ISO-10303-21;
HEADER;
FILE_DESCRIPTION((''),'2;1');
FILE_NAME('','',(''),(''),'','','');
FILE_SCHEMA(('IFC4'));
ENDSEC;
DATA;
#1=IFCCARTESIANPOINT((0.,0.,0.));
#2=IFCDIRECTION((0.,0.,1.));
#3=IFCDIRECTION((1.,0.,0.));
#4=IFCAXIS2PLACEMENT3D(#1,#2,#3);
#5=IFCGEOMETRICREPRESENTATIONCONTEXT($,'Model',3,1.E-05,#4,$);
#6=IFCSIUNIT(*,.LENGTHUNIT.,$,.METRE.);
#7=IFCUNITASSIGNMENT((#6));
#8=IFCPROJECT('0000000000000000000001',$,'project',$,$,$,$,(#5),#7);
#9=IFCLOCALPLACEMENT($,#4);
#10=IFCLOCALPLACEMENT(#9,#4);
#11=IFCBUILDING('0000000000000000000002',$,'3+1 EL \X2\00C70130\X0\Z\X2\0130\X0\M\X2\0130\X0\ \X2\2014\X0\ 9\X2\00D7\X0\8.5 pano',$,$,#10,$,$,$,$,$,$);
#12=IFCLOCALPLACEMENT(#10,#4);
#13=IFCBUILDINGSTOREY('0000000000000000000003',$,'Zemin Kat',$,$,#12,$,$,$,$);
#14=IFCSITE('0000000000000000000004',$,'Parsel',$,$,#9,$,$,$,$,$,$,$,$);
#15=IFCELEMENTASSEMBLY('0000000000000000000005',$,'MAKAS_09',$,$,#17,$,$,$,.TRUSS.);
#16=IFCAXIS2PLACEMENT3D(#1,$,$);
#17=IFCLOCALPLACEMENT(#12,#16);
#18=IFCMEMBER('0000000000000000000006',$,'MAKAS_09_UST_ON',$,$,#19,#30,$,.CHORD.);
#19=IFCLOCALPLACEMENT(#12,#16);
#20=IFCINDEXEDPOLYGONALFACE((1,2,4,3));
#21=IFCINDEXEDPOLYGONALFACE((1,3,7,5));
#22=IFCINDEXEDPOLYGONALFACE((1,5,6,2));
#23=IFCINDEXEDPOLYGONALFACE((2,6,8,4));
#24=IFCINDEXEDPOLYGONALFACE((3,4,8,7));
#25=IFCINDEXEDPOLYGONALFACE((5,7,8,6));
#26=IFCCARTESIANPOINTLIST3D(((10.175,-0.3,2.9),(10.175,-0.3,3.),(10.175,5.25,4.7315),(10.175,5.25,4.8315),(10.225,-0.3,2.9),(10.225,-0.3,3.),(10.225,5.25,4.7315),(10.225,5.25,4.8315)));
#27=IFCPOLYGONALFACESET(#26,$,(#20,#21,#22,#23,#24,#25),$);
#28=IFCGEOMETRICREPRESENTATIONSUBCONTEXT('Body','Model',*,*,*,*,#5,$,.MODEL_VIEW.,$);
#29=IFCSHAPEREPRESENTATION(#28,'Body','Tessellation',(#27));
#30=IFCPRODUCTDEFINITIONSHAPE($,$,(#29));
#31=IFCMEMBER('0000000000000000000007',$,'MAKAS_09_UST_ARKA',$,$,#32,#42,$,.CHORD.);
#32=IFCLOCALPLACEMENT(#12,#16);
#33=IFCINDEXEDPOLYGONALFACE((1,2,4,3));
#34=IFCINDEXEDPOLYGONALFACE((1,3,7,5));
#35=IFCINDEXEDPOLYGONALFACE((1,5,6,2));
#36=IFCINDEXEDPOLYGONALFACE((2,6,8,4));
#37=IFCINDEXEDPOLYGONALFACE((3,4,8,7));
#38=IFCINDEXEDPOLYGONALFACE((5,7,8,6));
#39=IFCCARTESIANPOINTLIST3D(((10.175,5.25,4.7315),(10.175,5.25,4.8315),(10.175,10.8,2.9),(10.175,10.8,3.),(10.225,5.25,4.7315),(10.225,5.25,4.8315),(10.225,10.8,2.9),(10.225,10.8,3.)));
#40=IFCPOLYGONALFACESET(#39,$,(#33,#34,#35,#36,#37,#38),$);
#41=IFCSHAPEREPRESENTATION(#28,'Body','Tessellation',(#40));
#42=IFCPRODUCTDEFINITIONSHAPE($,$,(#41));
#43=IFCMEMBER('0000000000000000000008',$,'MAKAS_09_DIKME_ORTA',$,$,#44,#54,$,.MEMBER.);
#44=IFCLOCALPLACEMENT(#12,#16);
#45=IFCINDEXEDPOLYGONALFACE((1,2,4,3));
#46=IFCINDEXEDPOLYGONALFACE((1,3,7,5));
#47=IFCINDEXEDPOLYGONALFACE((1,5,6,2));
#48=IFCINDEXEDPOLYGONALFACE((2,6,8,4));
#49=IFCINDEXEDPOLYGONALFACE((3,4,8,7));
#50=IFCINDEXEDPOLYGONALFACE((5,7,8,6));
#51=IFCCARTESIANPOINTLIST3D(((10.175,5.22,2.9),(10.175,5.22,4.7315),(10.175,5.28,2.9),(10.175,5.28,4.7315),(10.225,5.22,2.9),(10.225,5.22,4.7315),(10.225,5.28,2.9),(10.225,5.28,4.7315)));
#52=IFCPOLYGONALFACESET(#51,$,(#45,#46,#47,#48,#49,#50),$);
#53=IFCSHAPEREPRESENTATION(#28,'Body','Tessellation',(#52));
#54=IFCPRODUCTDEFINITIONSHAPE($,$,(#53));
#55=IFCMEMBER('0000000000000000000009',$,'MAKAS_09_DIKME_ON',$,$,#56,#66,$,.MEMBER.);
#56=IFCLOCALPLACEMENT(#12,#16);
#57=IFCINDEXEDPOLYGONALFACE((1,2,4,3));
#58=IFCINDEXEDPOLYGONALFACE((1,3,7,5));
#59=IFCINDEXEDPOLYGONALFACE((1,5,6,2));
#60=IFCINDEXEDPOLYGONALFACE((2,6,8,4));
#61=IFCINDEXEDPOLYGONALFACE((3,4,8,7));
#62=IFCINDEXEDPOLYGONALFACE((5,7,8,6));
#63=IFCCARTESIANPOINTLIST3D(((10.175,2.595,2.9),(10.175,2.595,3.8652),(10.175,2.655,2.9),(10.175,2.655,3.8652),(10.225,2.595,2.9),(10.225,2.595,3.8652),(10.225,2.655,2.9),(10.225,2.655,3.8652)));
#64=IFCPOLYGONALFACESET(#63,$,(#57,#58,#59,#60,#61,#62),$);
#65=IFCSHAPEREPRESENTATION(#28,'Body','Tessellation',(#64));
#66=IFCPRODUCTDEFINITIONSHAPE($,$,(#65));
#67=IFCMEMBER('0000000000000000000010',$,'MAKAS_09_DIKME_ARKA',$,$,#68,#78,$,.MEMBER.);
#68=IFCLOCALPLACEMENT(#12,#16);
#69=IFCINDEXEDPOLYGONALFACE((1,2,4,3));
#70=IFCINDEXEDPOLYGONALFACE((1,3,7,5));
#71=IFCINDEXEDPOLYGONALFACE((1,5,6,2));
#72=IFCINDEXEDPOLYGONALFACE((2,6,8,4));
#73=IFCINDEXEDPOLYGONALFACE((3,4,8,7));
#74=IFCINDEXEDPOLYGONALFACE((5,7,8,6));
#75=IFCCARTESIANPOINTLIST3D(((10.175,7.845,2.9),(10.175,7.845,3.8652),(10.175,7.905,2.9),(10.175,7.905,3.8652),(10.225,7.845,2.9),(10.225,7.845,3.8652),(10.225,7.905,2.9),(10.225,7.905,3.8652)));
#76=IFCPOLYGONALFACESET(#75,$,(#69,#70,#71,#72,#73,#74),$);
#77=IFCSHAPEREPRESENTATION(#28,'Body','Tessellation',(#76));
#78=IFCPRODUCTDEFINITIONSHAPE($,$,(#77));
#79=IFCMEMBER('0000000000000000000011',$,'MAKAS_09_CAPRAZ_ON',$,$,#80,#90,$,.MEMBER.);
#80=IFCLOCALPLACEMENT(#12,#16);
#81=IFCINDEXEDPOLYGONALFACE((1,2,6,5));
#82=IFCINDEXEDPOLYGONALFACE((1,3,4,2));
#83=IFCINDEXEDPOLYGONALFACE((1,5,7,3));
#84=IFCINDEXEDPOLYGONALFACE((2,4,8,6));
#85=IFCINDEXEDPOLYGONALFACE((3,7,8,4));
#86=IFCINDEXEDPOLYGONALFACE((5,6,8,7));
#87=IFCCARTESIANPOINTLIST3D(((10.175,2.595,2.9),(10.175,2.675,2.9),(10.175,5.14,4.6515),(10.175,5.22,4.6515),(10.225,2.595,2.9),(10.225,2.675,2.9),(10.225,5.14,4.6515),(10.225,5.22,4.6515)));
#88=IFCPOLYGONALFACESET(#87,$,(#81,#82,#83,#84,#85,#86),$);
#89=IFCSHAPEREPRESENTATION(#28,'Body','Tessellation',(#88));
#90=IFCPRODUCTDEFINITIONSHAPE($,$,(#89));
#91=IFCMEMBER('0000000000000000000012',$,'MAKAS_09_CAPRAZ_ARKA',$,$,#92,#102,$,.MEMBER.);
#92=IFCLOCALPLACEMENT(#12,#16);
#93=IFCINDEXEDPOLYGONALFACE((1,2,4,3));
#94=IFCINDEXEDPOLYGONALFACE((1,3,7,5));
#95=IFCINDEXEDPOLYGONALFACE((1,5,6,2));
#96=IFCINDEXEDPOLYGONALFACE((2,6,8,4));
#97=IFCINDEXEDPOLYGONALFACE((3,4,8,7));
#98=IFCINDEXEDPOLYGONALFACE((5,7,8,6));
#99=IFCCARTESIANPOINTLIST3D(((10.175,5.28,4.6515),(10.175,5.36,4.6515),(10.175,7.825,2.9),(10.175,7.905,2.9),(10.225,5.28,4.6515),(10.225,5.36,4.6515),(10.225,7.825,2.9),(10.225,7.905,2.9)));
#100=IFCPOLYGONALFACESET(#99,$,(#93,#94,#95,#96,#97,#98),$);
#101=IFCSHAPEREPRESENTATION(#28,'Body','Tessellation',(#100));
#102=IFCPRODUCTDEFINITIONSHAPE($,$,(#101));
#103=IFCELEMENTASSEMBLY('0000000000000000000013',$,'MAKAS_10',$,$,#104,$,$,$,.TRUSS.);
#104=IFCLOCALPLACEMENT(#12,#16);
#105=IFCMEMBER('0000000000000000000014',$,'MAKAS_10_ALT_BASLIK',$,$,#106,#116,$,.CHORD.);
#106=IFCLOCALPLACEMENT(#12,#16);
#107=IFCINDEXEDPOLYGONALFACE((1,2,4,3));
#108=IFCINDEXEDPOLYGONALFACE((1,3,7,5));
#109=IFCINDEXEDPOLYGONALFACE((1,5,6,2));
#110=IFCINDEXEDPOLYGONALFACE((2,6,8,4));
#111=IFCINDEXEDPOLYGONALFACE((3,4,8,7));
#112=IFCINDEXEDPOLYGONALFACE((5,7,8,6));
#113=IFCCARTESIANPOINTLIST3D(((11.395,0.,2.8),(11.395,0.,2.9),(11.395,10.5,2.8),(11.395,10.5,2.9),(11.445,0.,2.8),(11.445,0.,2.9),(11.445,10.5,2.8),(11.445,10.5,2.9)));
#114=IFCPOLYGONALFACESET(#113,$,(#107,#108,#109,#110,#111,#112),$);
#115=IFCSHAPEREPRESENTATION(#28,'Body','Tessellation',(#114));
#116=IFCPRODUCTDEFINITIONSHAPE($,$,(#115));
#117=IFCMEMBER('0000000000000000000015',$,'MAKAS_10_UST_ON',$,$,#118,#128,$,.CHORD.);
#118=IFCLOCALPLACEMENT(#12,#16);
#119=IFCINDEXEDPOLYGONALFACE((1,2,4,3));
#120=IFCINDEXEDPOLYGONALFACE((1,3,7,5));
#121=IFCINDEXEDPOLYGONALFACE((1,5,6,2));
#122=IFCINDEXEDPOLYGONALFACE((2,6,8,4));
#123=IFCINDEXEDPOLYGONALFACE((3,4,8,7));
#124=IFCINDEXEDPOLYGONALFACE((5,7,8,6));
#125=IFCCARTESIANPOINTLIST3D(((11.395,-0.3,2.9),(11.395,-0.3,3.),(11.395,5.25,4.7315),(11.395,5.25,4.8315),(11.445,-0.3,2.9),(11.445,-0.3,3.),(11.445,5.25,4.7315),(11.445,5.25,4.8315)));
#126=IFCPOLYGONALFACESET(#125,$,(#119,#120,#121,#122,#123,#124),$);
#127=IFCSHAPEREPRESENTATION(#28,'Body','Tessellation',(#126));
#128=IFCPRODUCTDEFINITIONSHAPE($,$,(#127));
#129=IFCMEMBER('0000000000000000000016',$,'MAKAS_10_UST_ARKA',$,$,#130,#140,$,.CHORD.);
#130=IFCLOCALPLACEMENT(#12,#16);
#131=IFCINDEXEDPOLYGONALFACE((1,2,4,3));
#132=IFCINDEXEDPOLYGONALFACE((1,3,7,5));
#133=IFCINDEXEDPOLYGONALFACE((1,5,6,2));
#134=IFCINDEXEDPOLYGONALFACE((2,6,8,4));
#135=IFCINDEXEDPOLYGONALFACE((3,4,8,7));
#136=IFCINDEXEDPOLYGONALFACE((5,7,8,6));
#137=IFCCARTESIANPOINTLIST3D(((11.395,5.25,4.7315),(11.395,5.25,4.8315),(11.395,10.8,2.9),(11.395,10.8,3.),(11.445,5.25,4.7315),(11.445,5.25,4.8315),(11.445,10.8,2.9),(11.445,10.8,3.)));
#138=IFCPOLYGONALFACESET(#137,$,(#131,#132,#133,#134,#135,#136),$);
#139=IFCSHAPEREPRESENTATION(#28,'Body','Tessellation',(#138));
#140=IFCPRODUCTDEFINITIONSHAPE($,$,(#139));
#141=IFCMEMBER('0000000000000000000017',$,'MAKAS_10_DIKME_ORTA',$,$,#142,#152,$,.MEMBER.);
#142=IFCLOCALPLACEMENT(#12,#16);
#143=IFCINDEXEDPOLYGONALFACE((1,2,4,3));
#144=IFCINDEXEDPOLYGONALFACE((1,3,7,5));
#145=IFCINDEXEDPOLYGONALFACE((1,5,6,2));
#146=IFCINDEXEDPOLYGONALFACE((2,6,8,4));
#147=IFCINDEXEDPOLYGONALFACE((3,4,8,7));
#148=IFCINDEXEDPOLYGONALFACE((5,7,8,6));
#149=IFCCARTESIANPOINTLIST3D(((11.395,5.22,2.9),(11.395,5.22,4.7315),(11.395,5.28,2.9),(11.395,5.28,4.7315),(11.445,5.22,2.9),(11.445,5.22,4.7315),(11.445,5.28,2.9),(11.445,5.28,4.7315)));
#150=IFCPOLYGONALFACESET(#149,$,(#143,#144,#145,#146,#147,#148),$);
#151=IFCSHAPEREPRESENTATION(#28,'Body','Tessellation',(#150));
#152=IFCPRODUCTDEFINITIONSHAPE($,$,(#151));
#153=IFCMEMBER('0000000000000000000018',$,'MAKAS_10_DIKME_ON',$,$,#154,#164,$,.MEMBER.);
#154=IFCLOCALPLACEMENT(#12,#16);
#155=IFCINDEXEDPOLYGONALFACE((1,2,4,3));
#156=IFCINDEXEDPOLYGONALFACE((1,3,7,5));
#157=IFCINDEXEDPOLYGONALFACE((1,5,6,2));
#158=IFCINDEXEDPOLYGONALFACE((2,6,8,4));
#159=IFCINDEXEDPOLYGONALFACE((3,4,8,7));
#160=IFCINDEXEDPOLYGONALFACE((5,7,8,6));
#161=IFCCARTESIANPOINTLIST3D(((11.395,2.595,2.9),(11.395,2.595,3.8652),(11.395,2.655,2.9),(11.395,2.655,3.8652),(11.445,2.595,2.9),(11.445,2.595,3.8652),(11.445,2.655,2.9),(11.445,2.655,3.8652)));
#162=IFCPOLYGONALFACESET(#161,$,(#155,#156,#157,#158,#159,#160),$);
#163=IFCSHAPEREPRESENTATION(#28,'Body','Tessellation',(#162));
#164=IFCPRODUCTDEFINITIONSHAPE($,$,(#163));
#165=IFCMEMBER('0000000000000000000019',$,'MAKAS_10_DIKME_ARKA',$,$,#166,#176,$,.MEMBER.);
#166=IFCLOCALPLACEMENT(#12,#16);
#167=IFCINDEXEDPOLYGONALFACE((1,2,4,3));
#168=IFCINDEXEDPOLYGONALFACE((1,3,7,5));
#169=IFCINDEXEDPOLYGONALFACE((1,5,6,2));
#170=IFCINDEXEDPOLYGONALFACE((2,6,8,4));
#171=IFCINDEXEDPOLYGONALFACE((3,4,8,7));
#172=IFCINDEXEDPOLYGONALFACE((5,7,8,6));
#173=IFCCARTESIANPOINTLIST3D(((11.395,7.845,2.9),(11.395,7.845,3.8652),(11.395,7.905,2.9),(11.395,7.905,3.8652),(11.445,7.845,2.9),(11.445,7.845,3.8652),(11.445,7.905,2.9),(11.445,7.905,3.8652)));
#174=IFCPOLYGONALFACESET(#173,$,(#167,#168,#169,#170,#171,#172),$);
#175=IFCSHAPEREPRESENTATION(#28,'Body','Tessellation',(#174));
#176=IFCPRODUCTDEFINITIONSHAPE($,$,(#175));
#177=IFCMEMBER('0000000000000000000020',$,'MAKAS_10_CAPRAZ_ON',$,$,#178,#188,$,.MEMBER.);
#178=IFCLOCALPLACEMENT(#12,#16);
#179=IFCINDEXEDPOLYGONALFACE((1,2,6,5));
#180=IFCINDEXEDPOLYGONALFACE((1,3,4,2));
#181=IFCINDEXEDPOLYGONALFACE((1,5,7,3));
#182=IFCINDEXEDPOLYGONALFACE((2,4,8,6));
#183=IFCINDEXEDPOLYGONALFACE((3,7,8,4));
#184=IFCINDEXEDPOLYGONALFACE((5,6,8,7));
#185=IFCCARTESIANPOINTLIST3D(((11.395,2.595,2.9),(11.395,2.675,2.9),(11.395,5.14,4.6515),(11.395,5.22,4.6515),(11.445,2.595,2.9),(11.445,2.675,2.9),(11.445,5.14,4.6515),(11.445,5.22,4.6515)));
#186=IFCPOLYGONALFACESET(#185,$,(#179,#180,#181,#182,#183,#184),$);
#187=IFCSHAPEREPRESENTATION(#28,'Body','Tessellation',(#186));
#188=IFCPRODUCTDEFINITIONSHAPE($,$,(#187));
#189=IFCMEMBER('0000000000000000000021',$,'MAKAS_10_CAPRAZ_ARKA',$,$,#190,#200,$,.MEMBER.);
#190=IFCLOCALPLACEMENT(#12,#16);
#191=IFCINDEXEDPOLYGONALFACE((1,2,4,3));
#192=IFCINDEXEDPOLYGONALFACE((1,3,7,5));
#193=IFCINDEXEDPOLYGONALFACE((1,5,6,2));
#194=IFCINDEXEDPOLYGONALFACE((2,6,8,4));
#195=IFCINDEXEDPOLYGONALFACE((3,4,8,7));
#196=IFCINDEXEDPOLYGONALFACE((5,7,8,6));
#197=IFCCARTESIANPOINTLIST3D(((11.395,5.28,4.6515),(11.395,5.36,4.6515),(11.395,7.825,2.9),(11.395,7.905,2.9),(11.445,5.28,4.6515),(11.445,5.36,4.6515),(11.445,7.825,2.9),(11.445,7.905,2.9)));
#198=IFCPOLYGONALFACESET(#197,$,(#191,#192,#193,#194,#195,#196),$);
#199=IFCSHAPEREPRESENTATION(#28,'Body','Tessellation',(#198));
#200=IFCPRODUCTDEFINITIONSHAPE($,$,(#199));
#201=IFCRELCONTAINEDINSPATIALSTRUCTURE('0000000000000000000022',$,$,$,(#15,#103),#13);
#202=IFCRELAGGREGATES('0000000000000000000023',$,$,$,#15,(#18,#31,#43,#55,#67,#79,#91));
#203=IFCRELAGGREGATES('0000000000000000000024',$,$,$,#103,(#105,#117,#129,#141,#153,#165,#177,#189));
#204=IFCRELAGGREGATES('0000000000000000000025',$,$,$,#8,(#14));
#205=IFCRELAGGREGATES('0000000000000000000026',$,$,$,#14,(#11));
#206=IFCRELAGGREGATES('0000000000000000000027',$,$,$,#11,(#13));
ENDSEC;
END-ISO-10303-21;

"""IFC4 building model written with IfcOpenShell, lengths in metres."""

from ifc_helpers import new_model, si_unit, frame, origin_with_axes, place, context, subcontext, project, spatial, line, indexed_curve, outline, extrude, element, aggregate, save


model = new_model("IFC4")

# Units and contexts
model_context = context("Model", 3, precision=1e-05, world=origin_with_axes())
body_context = subcontext(model_context, "Body", "Model", "MODEL_VIEW")
ifc_project = project(units=[si_unit("LENGTHUNIT", "METRE")], contexts=[model_context])

# Site, building, storey
site_placement = place(None, origin_with_axes())
site = spatial("IfcSite", under=ifc_project, at=site_placement, Name="Parsel")
building_placement = place(site_placement, origin_with_axes())
building = spatial("IfcBuilding", under=site, at=building_placement, Name="3+1 EL ÇİZİMİ — 9×8.5 pano")
storey_placement = place(building_placement, origin_with_axes())
storey = spatial("IfcBuildingStorey", under=building, at=storey_placement, Name="Zemin Kat")

# Element assemblies, members
assembly_1_placement = place(storey_placement, origin_with_axes())
assembly_1 = element("IfcElementAssembly", 1, at=assembly_1_placement, inside=storey, Name="MAKAS_09", PredefinedType="TRUSS")
member_1_placement = place(assembly_1_placement, origin_with_axes())
member_1 = element("IfcMember", 2, at=member_1_placement, Name="MAKAS_09_UST_ON", PredefinedType="CHORD", context=body_context, shape_type="SweptSolid", body=[
    extrude(outline(indexed_curve([(-0.3, 2.9), (5.25, 4.7315), (5.25, 4.8315), (-0.3, 3.0)], segments=[line(1, 2, 3, 4, 1)])), frame((10.175, 0.0, 0.0), z_axis=(1.0, 0.0, 0.0), x_axis=(0.0, 1.0, 0.0)), (0.0, 0.0, 1.0), 0.05),
])
member_2_placement = place(assembly_1_placement, origin_with_axes())
member_2 = element("IfcMember", 3, at=member_2_placement, Name="MAKAS_09_UST_ARKA", PredefinedType="CHORD", context=body_context, shape_type="SweptSolid", body=[
    extrude(outline(indexed_curve([(5.25, 4.7315), (10.8, 2.9), (10.8, 3.0), (5.25, 4.8315)], segments=[line(1, 2, 3, 4, 1)])), frame((10.175, 0.0, 0.0), z_axis=(1.0, 0.0, 0.0), x_axis=(0.0, 1.0, 0.0)), (0.0, 0.0, 1.0), 0.05),
])
member_3_placement = place(assembly_1_placement, origin_with_axes())
member_3 = element("IfcMember", 4, at=member_3_placement, Name="MAKAS_09_DIKME_ORTA", PredefinedType="MEMBER", context=body_context, shape_type="SweptSolid", body=[
    extrude(outline(indexed_curve([(5.22, 2.9), (5.28, 2.9), (5.28, 4.7315), (5.22, 4.7315)], segments=[line(1, 2, 3, 4, 1)])), frame((10.175, 0.0, 0.0), z_axis=(1.0, 0.0, 0.0), x_axis=(0.0, 1.0, 0.0)), (0.0, 0.0, 1.0), 0.05),
])
member_4_placement = place(assembly_1_placement, origin_with_axes())
member_4 = element("IfcMember", 5, at=member_4_placement, Name="MAKAS_09_DIKME_ON", PredefinedType="MEMBER", context=body_context, shape_type="SweptSolid", body=[
    extrude(outline(indexed_curve([(2.595, 2.9), (2.655, 2.9), (2.655, 3.8653), (2.595, 3.8653)], segments=[line(1, 2, 3, 4, 1)])), frame((10.175, 0.0, 0.0), z_axis=(1.0, 0.0, 0.0), x_axis=(0.0, 1.0, 0.0)), (0.0, 0.0, 1.0), 0.05),
])
member_5_placement = place(assembly_1_placement, origin_with_axes())
member_5 = element("IfcMember", 6, at=member_5_placement, Name="MAKAS_09_DIKME_ARKA", PredefinedType="MEMBER", context=body_context, shape_type="SweptSolid", body=[
    extrude(outline(indexed_curve([(7.845, 2.9), (7.905, 2.9), (7.905, 3.8653), (7.845, 3.8653)], segments=[line(1, 2, 3, 4, 1)])), frame((10.175, 0.0, 0.0), z_axis=(1.0, 0.0, 0.0), x_axis=(0.0, 1.0, 0.0)), (0.0, 0.0, 1.0), 0.05),
])
member_6_placement = place(assembly_1_placement, origin_with_axes())
member_6 = element("IfcMember", 7, at=member_6_placement, Name="MAKAS_09_CAPRAZ_ON", PredefinedType="MEMBER", context=body_context, shape_type="SweptSolid", body=[
    extrude(outline(indexed_curve([(2.595, 2.9), (2.675, 2.9), (5.22, 4.6515), (5.14, 4.6515)], segments=[line(1, 2, 3, 4, 1)])), frame((10.175, 0.0, 0.0), z_axis=(1.0, 0.0, 0.0), x_axis=(0.0, 1.0, 0.0)), (0.0, 0.0, 1.0), 0.05),
])
member_7_placement = place(assembly_1_placement, origin_with_axes())
member_7 = element("IfcMember", 8, at=member_7_placement, Name="MAKAS_09_CAPRAZ_ARKA", PredefinedType="MEMBER", context=body_context, shape_type="SweptSolid", body=[
    extrude(outline(indexed_curve([(7.825, 2.9), (7.905, 2.9), (5.36, 4.6515), (5.28, 4.6515)], segments=[line(1, 2, 3, 4, 1)])), frame((10.175, 0.0, 0.0), z_axis=(1.0, 0.0, 0.0), x_axis=(0.0, 1.0, 0.0)), (0.0, 0.0, 1.0), 0.05),
])
aggregate(assembly_1, [member_1, member_2, member_3, member_4, member_5, member_6, member_7])
assembly_2_placement = place(storey_placement, origin_with_axes())
assembly_2 = element("IfcElementAssembly", 9, at=assembly_2_placement, inside=storey, Name="MAKAS_10", PredefinedType="TRUSS")
member_8_placement = place(assembly_2_placement, origin_with_axes())
member_8 = element("IfcMember", 10, at=member_8_placement, Name="MAKAS_10_ALT_BASLIK", PredefinedType="CHORD", context=body_context, shape_type="SweptSolid", body=[
    extrude(outline(indexed_curve([(0.0, 2.8), (10.5, 2.8), (10.5, 2.9), (0.0, 2.9)], segments=[line(1, 2, 3, 4, 1)])), frame((11.395, 0.0, 0.0), z_axis=(1.0, 0.0, 0.0), x_axis=(0.0, 1.0, 0.0)), (0.0, 0.0, 1.0), 0.05),
])
member_9_placement = place(assembly_2_placement, origin_with_axes())
member_9 = element("IfcMember", 11, at=member_9_placement, Name="MAKAS_10_UST_ON", PredefinedType="CHORD", context=body_context, shape_type="SweptSolid", body=[
    extrude(outline(indexed_curve([(-0.3, 2.9), (5.25, 4.7315), (5.25, 4.8315), (-0.3, 3.0)], segments=[line(1, 2, 3, 4, 1)])), frame((11.395, 0.0, 0.0), z_axis=(1.0, 0.0, 0.0), x_axis=(0.0, 1.0, 0.0)), (0.0, 0.0, 1.0), 0.05),
])
member_10_placement = place(assembly_2_placement, origin_with_axes())
member_10 = element("IfcMember", 12, at=member_10_placement, Name="MAKAS_10_UST_ARKA", PredefinedType="CHORD", context=body_context, shape_type="SweptSolid", body=[
    extrude(outline(indexed_curve([(5.25, 4.7315), (10.8, 2.9), (10.8, 3.0), (5.25, 4.8315)], segments=[line(1, 2, 3, 4, 1)])), frame((11.395, 0.0, 0.0), z_axis=(1.0, 0.0, 0.0), x_axis=(0.0, 1.0, 0.0)), (0.0, 0.0, 1.0), 0.05),
])
member_11_placement = place(assembly_2_placement, origin_with_axes())
member_11 = element("IfcMember", 13, at=member_11_placement, Name="MAKAS_10_DIKME_ORTA", PredefinedType="MEMBER", context=body_context, shape_type="SweptSolid", body=[
    extrude(outline(indexed_curve([(5.22, 2.9), (5.28, 2.9), (5.28, 4.7315), (5.22, 4.7315)], segments=[line(1, 2, 3, 4, 1)])), frame((11.395, 0.0, 0.0), z_axis=(1.0, 0.0, 0.0), x_axis=(0.0, 1.0, 0.0)), (0.0, 0.0, 1.0), 0.05),
])
member_12_placement = place(assembly_2_placement, origin_with_axes())
member_12 = element("IfcMember", 14, at=member_12_placement, Name="MAKAS_10_DIKME_ON", PredefinedType="MEMBER", context=body_context, shape_type="SweptSolid", body=[
    extrude(outline(indexed_curve([(2.595, 2.9), (2.655, 2.9), (2.655, 3.8653), (2.595, 3.8653)], segments=[line(1, 2, 3, 4, 1)])), frame((11.395, 0.0, 0.0), z_axis=(1.0, 0.0, 0.0), x_axis=(0.0, 1.0, 0.0)), (0.0, 0.0, 1.0), 0.05),
])
member_13_placement = place(assembly_2_placement, origin_with_axes())
member_13 = element("IfcMember", 15, at=member_13_placement, Name="MAKAS_10_DIKME_ARKA", PredefinedType="MEMBER", context=body_context, shape_type="SweptSolid", body=[
    extrude(outline(indexed_curve([(7.845, 2.9), (7.905, 2.9), (7.905, 3.8653), (7.845, 3.8653)], segments=[line(1, 2, 3, 4, 1)])), frame((11.395, 0.0, 0.0), z_axis=(1.0, 0.0, 0.0), x_axis=(0.0, 1.0, 0.0)), (0.0, 0.0, 1.0), 0.05),
])
member_14_placement = place(assembly_2_placement, origin_with_axes())
member_14 = element("IfcMember", 16, at=member_14_placement, Name="MAKAS_10_CAPRAZ_ON", PredefinedType="MEMBER", context=body_context, shape_type="SweptSolid", body=[
    extrude(outline(indexed_curve([(2.595, 2.9), (2.675, 2.9), (5.22, 4.6515), (5.14, 4.6515)], segments=[line(1, 2, 3, 4, 1)])), frame((11.395, 0.0, 0.0), z_axis=(1.0, 0.0, 0.0), x_axis=(0.0, 1.0, 0.0)), (0.0, 0.0, 1.0), 0.05),
])
member_15_placement = place(assembly_2_placement, origin_with_axes())
member_15 = element("IfcMember", 17, at=member_15_placement, Name="MAKAS_10_CAPRAZ_ARKA", PredefinedType="MEMBER", context=body_context, shape_type="SweptSolid", body=[
    extrude(outline(indexed_curve([(7.825, 2.9), (7.905, 2.9), (5.36, 4.6515), (5.28, 4.6515)], segments=[line(1, 2, 3, 4, 1)])), frame((11.395, 0.0, 0.0), z_axis=(1.0, 0.0, 0.0), x_axis=(0.0, 1.0, 0.0)), (0.0, 0.0, 1.0), 0.05),
])
aggregate(assembly_2, [member_8, member_9, member_10, member_11, member_12, member_13, member_14, member_15])

save(model, "model.ifc")
